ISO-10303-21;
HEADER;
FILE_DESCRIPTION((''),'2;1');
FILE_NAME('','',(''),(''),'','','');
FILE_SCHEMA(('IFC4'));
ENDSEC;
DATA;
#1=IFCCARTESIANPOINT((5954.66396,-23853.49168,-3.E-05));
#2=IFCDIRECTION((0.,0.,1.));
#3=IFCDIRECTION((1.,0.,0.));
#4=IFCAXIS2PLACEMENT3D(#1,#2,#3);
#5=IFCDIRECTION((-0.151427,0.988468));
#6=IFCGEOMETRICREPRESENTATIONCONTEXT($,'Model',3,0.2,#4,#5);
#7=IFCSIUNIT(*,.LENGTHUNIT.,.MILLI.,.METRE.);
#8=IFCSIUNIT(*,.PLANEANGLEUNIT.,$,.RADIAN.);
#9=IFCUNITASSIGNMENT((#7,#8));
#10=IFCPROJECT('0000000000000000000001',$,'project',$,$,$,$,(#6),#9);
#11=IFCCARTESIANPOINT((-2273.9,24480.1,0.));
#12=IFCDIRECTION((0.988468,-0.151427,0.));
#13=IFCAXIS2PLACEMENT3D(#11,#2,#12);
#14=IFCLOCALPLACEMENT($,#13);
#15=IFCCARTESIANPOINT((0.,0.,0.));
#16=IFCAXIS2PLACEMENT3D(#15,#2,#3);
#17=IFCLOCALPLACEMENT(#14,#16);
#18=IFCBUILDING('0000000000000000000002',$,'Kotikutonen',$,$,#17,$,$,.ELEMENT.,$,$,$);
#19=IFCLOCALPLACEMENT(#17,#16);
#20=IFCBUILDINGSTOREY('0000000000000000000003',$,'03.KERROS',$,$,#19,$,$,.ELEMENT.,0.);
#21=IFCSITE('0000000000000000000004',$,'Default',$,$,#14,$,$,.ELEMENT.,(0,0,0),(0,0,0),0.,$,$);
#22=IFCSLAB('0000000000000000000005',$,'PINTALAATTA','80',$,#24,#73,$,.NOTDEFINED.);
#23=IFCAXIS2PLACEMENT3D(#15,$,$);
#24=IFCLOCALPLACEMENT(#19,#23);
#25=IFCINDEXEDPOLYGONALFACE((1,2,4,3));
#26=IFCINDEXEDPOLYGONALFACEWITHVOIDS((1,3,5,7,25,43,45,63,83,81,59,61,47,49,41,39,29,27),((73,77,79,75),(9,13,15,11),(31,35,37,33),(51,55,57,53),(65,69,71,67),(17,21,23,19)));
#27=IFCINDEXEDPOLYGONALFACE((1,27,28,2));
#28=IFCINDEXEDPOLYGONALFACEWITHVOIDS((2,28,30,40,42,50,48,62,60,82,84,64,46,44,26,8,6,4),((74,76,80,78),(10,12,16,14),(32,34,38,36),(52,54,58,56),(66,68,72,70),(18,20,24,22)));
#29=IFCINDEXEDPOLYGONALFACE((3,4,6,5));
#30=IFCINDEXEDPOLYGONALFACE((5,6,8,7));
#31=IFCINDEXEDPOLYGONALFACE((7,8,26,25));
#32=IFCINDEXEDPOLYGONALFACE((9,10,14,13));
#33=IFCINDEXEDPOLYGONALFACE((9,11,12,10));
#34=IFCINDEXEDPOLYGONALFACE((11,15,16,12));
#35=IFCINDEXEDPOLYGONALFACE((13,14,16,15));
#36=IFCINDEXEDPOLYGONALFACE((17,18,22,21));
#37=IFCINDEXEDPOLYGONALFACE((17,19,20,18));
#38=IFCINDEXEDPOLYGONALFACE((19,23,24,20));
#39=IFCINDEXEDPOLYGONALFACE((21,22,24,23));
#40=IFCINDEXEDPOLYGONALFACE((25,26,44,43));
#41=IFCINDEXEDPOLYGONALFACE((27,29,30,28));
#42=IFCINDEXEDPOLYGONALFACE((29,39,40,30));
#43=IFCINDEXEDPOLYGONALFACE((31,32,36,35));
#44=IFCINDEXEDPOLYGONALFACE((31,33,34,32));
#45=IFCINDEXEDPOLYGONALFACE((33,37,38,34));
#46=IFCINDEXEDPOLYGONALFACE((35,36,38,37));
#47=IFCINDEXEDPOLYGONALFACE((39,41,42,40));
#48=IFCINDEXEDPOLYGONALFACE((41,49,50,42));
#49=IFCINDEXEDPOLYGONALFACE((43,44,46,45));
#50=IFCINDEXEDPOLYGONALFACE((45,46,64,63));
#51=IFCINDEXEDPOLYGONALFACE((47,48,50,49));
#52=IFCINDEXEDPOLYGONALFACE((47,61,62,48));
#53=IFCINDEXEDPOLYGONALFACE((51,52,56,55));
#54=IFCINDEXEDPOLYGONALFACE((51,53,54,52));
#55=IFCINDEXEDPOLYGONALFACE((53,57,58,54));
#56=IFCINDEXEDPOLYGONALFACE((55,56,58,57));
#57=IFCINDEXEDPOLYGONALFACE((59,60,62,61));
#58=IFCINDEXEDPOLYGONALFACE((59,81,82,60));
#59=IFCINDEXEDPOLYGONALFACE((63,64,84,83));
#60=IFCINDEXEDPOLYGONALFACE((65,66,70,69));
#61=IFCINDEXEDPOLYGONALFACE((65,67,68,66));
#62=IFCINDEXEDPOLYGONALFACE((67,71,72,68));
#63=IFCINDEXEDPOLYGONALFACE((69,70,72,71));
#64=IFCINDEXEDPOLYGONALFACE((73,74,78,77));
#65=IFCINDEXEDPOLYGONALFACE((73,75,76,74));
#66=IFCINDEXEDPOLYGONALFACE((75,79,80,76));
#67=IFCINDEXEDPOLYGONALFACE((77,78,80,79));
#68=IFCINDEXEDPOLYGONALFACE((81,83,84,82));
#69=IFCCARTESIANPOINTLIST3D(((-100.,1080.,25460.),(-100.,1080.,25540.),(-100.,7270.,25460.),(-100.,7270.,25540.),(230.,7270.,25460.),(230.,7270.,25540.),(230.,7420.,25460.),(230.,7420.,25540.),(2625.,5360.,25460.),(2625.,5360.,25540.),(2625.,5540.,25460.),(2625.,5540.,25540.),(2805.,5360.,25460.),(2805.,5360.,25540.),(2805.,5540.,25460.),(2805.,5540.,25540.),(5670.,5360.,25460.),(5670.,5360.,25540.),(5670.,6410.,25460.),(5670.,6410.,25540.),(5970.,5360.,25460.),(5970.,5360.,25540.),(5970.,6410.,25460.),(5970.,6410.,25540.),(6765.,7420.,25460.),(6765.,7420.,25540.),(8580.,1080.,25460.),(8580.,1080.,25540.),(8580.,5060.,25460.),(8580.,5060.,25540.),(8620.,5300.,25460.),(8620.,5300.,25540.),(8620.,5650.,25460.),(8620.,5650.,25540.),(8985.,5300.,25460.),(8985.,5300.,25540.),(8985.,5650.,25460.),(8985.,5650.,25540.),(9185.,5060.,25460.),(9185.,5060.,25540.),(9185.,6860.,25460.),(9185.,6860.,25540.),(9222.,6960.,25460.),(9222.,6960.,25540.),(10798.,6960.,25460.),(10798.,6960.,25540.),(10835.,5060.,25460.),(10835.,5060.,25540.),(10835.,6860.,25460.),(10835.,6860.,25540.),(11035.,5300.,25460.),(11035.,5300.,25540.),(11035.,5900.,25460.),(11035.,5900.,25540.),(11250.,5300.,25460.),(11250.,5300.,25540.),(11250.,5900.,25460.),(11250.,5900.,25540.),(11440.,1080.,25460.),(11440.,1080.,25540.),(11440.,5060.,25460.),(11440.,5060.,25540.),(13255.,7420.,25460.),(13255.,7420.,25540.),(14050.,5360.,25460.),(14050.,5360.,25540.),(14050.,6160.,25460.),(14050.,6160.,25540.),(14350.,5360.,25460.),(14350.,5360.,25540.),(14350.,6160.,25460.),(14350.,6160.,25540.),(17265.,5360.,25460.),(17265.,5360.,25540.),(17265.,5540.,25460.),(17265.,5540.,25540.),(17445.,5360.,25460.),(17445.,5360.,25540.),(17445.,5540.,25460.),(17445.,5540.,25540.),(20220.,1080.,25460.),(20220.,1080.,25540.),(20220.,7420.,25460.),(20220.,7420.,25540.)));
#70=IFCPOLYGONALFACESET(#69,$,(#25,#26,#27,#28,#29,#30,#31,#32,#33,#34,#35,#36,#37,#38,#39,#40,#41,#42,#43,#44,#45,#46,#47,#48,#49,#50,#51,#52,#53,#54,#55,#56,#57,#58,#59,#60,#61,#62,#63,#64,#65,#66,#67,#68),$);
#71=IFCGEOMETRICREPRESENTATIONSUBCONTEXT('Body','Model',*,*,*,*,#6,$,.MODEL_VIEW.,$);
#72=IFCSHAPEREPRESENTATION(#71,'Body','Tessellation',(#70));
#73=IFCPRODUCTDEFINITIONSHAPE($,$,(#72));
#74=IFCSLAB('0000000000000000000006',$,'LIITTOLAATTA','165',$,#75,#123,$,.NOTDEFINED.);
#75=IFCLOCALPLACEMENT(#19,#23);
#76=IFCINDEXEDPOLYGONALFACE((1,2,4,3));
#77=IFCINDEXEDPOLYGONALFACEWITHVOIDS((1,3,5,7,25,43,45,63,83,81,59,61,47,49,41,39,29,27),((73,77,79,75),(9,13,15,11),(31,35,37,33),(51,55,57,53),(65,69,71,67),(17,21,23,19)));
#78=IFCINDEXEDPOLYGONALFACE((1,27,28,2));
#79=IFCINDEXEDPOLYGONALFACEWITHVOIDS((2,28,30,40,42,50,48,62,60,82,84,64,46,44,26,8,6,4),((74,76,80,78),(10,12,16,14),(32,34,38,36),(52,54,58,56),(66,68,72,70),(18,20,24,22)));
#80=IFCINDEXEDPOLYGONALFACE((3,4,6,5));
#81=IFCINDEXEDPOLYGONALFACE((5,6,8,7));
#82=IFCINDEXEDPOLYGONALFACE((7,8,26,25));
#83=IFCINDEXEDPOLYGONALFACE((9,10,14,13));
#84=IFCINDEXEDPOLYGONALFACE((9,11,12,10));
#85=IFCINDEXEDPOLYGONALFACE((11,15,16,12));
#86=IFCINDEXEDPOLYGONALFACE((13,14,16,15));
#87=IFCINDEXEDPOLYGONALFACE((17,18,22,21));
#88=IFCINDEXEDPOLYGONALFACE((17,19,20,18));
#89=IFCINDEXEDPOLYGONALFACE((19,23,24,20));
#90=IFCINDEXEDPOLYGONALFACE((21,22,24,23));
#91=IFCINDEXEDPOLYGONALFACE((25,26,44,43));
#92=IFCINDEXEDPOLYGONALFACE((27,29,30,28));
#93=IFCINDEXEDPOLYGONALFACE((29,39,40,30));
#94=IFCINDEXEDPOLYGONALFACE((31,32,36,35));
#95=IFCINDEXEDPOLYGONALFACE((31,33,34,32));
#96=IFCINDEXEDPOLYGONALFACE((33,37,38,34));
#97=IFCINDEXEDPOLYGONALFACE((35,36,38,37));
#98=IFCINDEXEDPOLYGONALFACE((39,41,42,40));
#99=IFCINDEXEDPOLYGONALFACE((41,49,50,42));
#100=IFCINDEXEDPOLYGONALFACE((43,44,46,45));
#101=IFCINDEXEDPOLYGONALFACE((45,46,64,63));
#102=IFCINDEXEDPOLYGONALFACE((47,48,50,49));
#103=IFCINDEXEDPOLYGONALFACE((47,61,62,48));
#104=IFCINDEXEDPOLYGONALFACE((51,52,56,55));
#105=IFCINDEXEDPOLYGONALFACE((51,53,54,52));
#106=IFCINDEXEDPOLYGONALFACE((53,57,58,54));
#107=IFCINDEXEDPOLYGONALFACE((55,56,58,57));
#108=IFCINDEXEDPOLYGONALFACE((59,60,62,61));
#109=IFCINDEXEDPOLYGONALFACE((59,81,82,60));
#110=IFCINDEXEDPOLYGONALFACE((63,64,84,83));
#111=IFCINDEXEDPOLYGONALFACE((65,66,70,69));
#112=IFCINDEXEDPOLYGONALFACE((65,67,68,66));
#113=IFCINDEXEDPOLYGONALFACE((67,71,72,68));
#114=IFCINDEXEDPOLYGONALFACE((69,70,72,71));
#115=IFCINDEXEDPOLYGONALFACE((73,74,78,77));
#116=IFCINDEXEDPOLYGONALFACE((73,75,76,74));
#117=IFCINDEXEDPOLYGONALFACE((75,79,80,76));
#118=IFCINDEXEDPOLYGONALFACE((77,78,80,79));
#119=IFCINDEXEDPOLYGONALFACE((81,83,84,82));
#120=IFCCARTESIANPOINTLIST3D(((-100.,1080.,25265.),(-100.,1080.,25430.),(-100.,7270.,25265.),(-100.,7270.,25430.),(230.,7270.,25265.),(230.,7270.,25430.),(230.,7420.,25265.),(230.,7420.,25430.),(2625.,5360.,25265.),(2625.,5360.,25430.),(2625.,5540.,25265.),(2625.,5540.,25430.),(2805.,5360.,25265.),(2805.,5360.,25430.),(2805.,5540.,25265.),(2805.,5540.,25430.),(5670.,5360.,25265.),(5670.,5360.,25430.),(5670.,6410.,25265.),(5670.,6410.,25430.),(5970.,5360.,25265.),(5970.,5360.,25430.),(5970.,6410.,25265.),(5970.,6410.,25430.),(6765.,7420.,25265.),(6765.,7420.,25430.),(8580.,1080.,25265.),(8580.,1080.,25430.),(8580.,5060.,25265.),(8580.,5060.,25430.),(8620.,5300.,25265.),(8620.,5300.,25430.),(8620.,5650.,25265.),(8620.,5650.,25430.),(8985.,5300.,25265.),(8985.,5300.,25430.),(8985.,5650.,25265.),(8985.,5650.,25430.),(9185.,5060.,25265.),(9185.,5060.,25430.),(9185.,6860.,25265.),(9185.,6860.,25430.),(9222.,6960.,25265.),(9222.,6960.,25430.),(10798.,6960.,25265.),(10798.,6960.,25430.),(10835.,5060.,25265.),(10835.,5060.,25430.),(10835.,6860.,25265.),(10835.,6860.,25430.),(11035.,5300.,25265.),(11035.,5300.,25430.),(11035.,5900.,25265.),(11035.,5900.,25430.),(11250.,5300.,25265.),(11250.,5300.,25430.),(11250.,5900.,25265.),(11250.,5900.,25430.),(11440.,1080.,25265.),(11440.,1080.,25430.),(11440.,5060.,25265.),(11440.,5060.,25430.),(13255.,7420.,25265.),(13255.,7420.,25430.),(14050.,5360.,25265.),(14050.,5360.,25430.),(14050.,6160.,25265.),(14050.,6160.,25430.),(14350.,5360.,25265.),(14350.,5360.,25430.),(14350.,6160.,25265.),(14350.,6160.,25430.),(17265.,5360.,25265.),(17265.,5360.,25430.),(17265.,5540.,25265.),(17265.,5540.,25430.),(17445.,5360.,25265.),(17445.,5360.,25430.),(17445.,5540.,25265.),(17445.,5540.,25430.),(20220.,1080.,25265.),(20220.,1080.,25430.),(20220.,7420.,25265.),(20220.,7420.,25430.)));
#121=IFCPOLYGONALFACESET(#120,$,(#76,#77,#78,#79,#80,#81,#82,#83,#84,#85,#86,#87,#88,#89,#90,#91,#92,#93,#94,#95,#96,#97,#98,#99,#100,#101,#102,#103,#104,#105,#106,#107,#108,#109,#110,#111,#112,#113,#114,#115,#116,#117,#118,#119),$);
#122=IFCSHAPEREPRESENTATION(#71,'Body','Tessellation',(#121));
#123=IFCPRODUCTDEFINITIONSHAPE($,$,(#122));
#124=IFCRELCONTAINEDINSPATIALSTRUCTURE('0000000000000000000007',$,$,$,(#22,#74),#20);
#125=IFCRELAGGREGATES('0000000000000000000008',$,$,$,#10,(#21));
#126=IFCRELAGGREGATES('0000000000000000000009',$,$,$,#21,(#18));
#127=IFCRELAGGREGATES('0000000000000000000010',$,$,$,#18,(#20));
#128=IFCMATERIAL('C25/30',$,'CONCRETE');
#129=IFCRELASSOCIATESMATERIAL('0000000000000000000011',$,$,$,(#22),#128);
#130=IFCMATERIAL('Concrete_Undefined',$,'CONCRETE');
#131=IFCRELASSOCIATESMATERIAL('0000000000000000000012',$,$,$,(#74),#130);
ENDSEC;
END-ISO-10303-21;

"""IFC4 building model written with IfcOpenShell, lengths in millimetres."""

from ifc_helpers import new_model, si_unit, direction, frame, origin_with_axes, place, context, subcontext, project, spatial, line, indexed_curve, outline, extrude, material, element, save


model = new_model("IFC4")

# Units and contexts
model_context = context("Model", 3, precision=0.2, world=frame((5954.66396, -23853.49168, -3e-05), z_axis=(0.0, 0.0, 1.0), x_axis=(1.0, 0.0, 0.0)), true_north=direction((-0.151427, 0.988468)))
body_context = subcontext(model_context, "Body", "Model", "MODEL_VIEW")
ifc_project = project(units=[si_unit("LENGTHUNIT", "METRE", prefix="MILLI"), si_unit("PLANEANGLEUNIT", "RADIAN")], contexts=[model_context])

# Site, building, storey
site_placement = place(None, frame((-2273.9, 24480.1, 0.0), z_axis=(0.0, 0.0, 1.0), x_axis=(0.988468, -0.151427, 0.0)))
site = spatial("IfcSite", under=ifc_project, at=site_placement, Name="Default", CompositionType="ELEMENT", RefLatitude=(0, 0, 0), RefLongitude=(0, 0, 0), RefElevation=0.0)
building_placement = place(site_placement, origin_with_axes())
building = spatial("IfcBuilding", under=site, at=building_placement, Name="Kotikutonen", CompositionType="ELEMENT")
storey_placement = place(building_placement, origin_with_axes())
storey = spatial("IfcBuildingStorey", under=building, at=storey_placement, Name="03.KERROS", CompositionType="ELEMENT", Elevation=0.0)

# Shared definitions
ifc_material_1 = material(Name="Concrete_Undefined", Category="CONCRETE")

# Slabs, voiding features
ifc_material_2 = material(Name="C25/30", Category="CONCRETE")
slab_1_placement = place(storey_placement, frame((-100.0, 7270.0, 25500.0), z_axis=(0.0, 0.0, 1.0), x_axis=(0.0, -1.0, 0.0)))
slab_1 = element("IfcSlab", 1, at=slab_1_placement, inside=storey, material=ifc_material_2, Name="PINTALAATTA", Description="80", PredefinedType="NOTDEFINED", context=body_context, shape_type="SolidModel", body=[
    extrude(outline(indexed_curve([(0.0, 0.0), (6190.0, 0.0), (6190.0, 8680.0), (7270.0, 8680.0), (7270.0, 11540.0), (6190.0, 11540.0), (6190.0, 20320.0), (-150.0, 20320.0), (-150.0, 13355.0), (310.0, 10898.0), (310.0, 9322.0), (-150.0, 6865.0), (-150.0, 330.0), (0.0, 330.0)], segments=[line(1, 2, 3, 4, 5, 6, 7, 8, 9, 10, 11, 12, 13, 14, 1)])), frame((0.0, 0.0, 40.0), z_axis=(0.0, 0.0, 1.0), x_axis=(1.0, 0.0, 0.0)), (0.0, 0.0, -1.0), 80.0),
])
voiding_feature_1_placement = place(slab_1_placement, frame((2210.0, 8680.0, 0.0), z_axis=(0.0, 0.0, 1.0), x_axis=(1.0, 0.0, 0.0)))
element("IfcVoidingFeature", 2, at=voiding_feature_1_placement, cuts=slab_1, Name="POLYGON CUT", PredefinedType="HOLE", context=body_context, shape_type="SolidModel", body=[
    extrude(outline(indexed_curve([(0.0, 0.0), (5060.0, 0.0), (5060.0, 2860.0), (0.0, 2860.0), (0.0, 2255.0), (-1800.0, 2255.0), (-1800.0, 605.0), (0.0, 605.0)], segments=[line(1, 2, 3, 4, 5, 6, 7, 8, 1)])), frame((0.0, 0.0, 115.0), z_axis=(0.0, 0.0, 1.0), x_axis=(1.0, 0.0, 0.0)), (0.0, 0.0, -1.0), 230.0),
])
voiding_feature_2_placement = place(slab_1_placement, frame((1620.0, 8720.0, 0.0), z_axis=(0.0, 0.0, 1.0), x_axis=(1.0, 0.0, 0.0)))
element("IfcVoidingFeature", 3, at=voiding_feature_2_placement, cuts=slab_1, Name="POLYGON CUT", PredefinedType="HOLE", context=body_context, shape_type="SolidModel", body=[
    extrude(outline(indexed_curve([(0.0, 0.0), (350.0, 0.0), (350.0, 365.0), (0.0, 365.0)], segments=[line(1, 2, 3, 4, 1)])), frame((0.0, 0.0, 115.0), z_axis=(0.0, 0.0, 1.0), x_axis=(1.0, 0.0, 0.0)), (0.0, 0.0, -1.0), 230.0),
])
voiding_feature_3_placement = place(slab_1_placement, frame((1370.0, 11135.0, 0.0), z_axis=(0.0, 0.0, 1.0), x_axis=(1.0, 0.0, 0.0)))
element("IfcVoidingFeature", 4, at=voiding_feature_3_placement, cuts=slab_1, Name="POLYGON CUT", PredefinedType="HOLE", context=body_context, shape_type="SolidModel", body=[
    extrude(outline(indexed_curve([(0.0, 0.0), (600.0, 0.0), (600.0, 215.0), (0.0, 215.0)], segments=[line(1, 2, 3, 4, 1)])), frame((0.0, 0.0, 115.0), z_axis=(0.0, 0.0, 1.0), x_axis=(1.0, 0.0, 0.0)), (0.0, 0.0, -1.0), 230.0),
])
voiding_feature_4_placement = place(slab_1_placement, frame((860.0, 5770.0, 0.0), z_axis=(0.0, 0.0, 1.0), x_axis=(1.0, 0.0, 0.0)))
element("IfcVoidingFeature", 5, at=voiding_feature_4_placement, cuts=slab_1, Name="POLYGON CUT", PredefinedType="HOLE", context=body_context, shape_type="SolidModel", body=[
    extrude(outline(indexed_curve([(0.0, 0.0), (1050.0, 0.0), (1050.0, 300.0), (0.0, 300.0)], segments=[line(1, 2, 3, 4, 1)])), frame((0.0, 0.0, 115.0), z_axis=(0.0, 0.0, 1.0), x_axis=(1.0, 0.0, 0.0)), (0.0, 0.0, -1.0), 230.0),
])
voiding_feature_5_placement = place(slab_1_placement, frame((1110.0, 14150.0, 0.0), z_axis=(0.0, 0.0, 1.0), x_axis=(1.0, 0.0, 0.0)))
element("IfcVoidingFeature", 6, at=voiding_feature_5_placement, cuts=slab_1, Name="POLYGON CUT", PredefinedType="HOLE", context=body_context, shape_type="SolidModel", body=[
    extrude(outline(indexed_curve([(0.0, 0.0), (800.0, 0.0), (800.0, 300.0), (0.0, 300.0)], segments=[line(1, 2, 3, 4, 1)])), frame((0.0, 0.0, 115.0), z_axis=(0.0, 0.0, 1.0), x_axis=(1.0, 0.0, 0.0)), (0.0, 0.0, -1.0), 230.0),
])
voiding_feature_6_placement = place(slab_1_placement, frame((1730.0, 2725.0, 0.0), z_axis=(0.0, 0.0, 1.0), x_axis=(1.0, 0.0, 0.0)))
element("IfcVoidingFeature", 7, at=voiding_feature_6_placement, cuts=slab_1, Name="POLYGON CUT", PredefinedType="HOLE", context=body_context, shape_type="SolidModel", body=[
    extrude(outline(indexed_curve([(0.0, 0.0), (180.0, 0.0), (180.0, 180.0), (0.0, 180.0)], segments=[line(1, 2, 3, 4, 1)])), frame((0.0, 0.0, 115.0), z_axis=(0.0, 0.0, 1.0), x_axis=(1.0, 0.0, 0.0)), (0.0, 0.0, -1.0), 230.0),
])
voiding_feature_7_placement = place(slab_1_placement, frame((1730.0, 17365.0, 0.0), z_axis=(0.0, 0.0, 1.0), x_axis=(1.0, 0.0, 0.0)))
element("IfcVoidingFeature", 8, at=voiding_feature_7_placement, cuts=slab_1, Name="POLYGON CUT", PredefinedType="HOLE", context=body_context, shape_type="SolidModel", body=[
    extrude(outline(indexed_curve([(0.0, 0.0), (180.0, 0.0), (180.0, 180.0), (0.0, 180.0)], segments=[line(1, 2, 3, 4, 1)])), frame((0.0, 0.0, 115.0), z_axis=(0.0, 0.0, 1.0), x_axis=(1.0, 0.0, 0.0)), (0.0, 0.0, -1.0), 230.0),
])
slab_2_placement = place(storey_placement, frame((-100.0, 7270.0, 25347.5), z_axis=(0.0, 0.0, 1.0), x_axis=(0.0, -1.0, 0.0)))
slab_2 = element("IfcSlab", 9, at=slab_2_placement, inside=storey, material=ifc_material_1, Name="LIITTOLAATTA", Description="165", PredefinedType="NOTDEFINED", context=body_context, shape_type="SolidModel", body=[
    extrude(outline(indexed_curve([(0.0, 0.0), (6190.0, 0.0), (6190.0, 8680.0), (7270.0, 8680.0), (7270.0, 11540.0), (6190.0, 11540.0), (6190.0, 20320.0), (-150.0, 20320.0), (-150.0, 13355.0), (310.0, 10898.0), (310.0, 9322.0), (-150.0, 6865.0), (-150.0, 330.0), (0.0, 330.0)], segments=[line(1, 2, 3, 4, 5, 6, 7, 8, 9, 10, 11, 12, 13, 14, 1)])), frame((0.0, 0.0, 82.5), z_axis=(0.0, 0.0, 1.0), x_axis=(1.0, 0.0, 0.0)), (0.0, 0.0, -1.0), 165.0),
])
voiding_feature_8_placement = place(slab_2_placement, frame((2210.0, 8680.0, 0.0), z_axis=(0.0, 0.0, 1.0), x_axis=(1.0, 0.0, 0.0)))
element("IfcVoidingFeature", 10, at=voiding_feature_8_placement, cuts=slab_2, Name="POLYGON CUT", PredefinedType="HOLE", context=body_context, shape_type="SolidModel", body=[
    extrude(outline(indexed_curve([(0.0, 0.0), (5060.0, 0.0), (5060.0, 2860.0), (0.0, 2860.0), (0.0, 2255.0), (-1800.0, 2255.0), (-1800.0, 605.0), (0.0, 605.0)], segments=[line(1, 2, 3, 4, 5, 6, 7, 8, 1)])), frame((0.0, 0.0, 157.5), z_axis=(0.0, 0.0, 1.0), x_axis=(1.0, 0.0, 0.0)), (0.0, 0.0, -1.0), 315.0),
])
voiding_feature_9_placement = place(slab_2_placement, frame((1620.0, 8720.0, 0.0), z_axis=(0.0, 0.0, 1.0), x_axis=(1.0, 0.0, 0.0)))
element("IfcVoidingFeature", 11, at=voiding_feature_9_placement, cuts=slab_2, Name="POLYGON CUT", PredefinedType="HOLE", context=body_context, shape_type="SolidModel", body=[
    extrude(outline(indexed_curve([(0.0, 0.0), (350.0, 0.0), (350.0, 365.0), (0.0, 365.0)], segments=[line(1, 2, 3, 4, 1)])), frame((0.0, 0.0, 157.5), z_axis=(0.0, 0.0, 1.0), x_axis=(1.0, 0.0, 0.0)), (0.0, 0.0, -1.0), 315.0),
])
voiding_feature_10_placement = place(slab_2_placement, frame((1370.0, 11135.0, 0.0), z_axis=(0.0, 0.0, 1.0), x_axis=(1.0, 0.0, 0.0)))
element("IfcVoidingFeature", 12, at=voiding_feature_10_placement, cuts=slab_2, Name="POLYGON CUT", PredefinedType="HOLE", context=body_context, shape_type="SolidModel", body=[
    extrude(outline(indexed_curve([(0.0, 0.0), (600.0, 0.0), (600.0, 215.0), (0.0, 215.0)], segments=[line(1, 2, 3, 4, 1)])), frame((0.0, 0.0, 157.5), z_axis=(0.0, 0.0, 1.0), x_axis=(1.0, 0.0, 0.0)), (0.0, 0.0, -1.0), 315.0),
])
voiding_feature_11_placement = place(slab_2_placement, frame((860.0, 5770.0, 0.0), z_axis=(0.0, 0.0, 1.0), x_axis=(1.0, 0.0, 0.0)))
element("IfcVoidingFeature", 13, at=voiding_feature_11_placement, cuts=slab_2, Name="POLYGON CUT", PredefinedType="HOLE", context=body_context, shape_type="SolidModel", body=[
    extrude(outline(indexed_curve([(0.0, 0.0), (1050.0, 0.0), (1050.0, 300.0), (0.0, 300.0)], segments=[line(1, 2, 3, 4, 1)])), frame((0.0, 0.0, 157.5), z_axis=(0.0, 0.0, 1.0), x_axis=(1.0, 0.0, 0.0)), (0.0, 0.0, -1.0), 315.0),
])
voiding_feature_12_placement = place(slab_2_placement, frame((1110.0, 14150.0, 0.0), z_axis=(0.0, 0.0, 1.0), x_axis=(1.0, 0.0, 0.0)))
element("IfcVoidingFeature", 14, at=voiding_feature_12_placement, cuts=slab_2, Name="POLYGON CUT", PredefinedType="HOLE", context=body_context, shape_type="SolidModel", body=[
    extrude(outline(indexed_curve([(0.0, 0.0), (800.0, 0.0), (800.0, 300.0), (0.0, 300.0)], segments=[line(1, 2, 3, 4, 1)])), frame((0.0, 0.0, 157.5), z_axis=(0.0, 0.0, 1.0), x_axis=(1.0, 0.0, 0.0)), (0.0, 0.0, -1.0), 315.0),
])
voiding_feature_13_placement = place(slab_2_placement, frame((1730.0, 2725.0, 0.0), z_axis=(0.0, 0.0, 1.0), x_axis=(1.0, 0.0, 0.0)))
element("IfcVoidingFeature", 15, at=voiding_feature_13_placement, cuts=slab_2, Name="POLYGON CUT", PredefinedType="HOLE", context=body_context, shape_type="SolidModel", body=[
    extrude(outline(indexed_curve([(0.0, 0.0), (180.0, 0.0), (180.0, 180.0), (0.0, 180.0)], segments=[line(1, 2, 3, 4, 1)])), frame((0.0, 0.0, 157.5), z_axis=(0.0, 0.0, 1.0), x_axis=(1.0, 0.0, 0.0)), (0.0, 0.0, -1.0), 315.0),
])
voiding_feature_14_placement = place(slab_2_placement, frame((1730.0, 17365.0, 0.0), z_axis=(0.0, 0.0, 1.0), x_axis=(1.0, 0.0, 0.0)))
element("IfcVoidingFeature", 16, at=voiding_feature_14_placement, cuts=slab_2, Name="POLYGON CUT", PredefinedType="HOLE", context=body_context, shape_type="SolidModel", body=[
    extrude(outline(indexed_curve([(0.0, 0.0), (180.0, 0.0), (180.0, 180.0), (0.0, 180.0)], segments=[line(1, 2, 3, 4, 1)])), frame((0.0, 0.0, 157.5), z_axis=(0.0, 0.0, 1.0), x_axis=(1.0, 0.0, 0.0)), (0.0, 0.0, -1.0), 315.0),
])

save(model, "model.ifc")
